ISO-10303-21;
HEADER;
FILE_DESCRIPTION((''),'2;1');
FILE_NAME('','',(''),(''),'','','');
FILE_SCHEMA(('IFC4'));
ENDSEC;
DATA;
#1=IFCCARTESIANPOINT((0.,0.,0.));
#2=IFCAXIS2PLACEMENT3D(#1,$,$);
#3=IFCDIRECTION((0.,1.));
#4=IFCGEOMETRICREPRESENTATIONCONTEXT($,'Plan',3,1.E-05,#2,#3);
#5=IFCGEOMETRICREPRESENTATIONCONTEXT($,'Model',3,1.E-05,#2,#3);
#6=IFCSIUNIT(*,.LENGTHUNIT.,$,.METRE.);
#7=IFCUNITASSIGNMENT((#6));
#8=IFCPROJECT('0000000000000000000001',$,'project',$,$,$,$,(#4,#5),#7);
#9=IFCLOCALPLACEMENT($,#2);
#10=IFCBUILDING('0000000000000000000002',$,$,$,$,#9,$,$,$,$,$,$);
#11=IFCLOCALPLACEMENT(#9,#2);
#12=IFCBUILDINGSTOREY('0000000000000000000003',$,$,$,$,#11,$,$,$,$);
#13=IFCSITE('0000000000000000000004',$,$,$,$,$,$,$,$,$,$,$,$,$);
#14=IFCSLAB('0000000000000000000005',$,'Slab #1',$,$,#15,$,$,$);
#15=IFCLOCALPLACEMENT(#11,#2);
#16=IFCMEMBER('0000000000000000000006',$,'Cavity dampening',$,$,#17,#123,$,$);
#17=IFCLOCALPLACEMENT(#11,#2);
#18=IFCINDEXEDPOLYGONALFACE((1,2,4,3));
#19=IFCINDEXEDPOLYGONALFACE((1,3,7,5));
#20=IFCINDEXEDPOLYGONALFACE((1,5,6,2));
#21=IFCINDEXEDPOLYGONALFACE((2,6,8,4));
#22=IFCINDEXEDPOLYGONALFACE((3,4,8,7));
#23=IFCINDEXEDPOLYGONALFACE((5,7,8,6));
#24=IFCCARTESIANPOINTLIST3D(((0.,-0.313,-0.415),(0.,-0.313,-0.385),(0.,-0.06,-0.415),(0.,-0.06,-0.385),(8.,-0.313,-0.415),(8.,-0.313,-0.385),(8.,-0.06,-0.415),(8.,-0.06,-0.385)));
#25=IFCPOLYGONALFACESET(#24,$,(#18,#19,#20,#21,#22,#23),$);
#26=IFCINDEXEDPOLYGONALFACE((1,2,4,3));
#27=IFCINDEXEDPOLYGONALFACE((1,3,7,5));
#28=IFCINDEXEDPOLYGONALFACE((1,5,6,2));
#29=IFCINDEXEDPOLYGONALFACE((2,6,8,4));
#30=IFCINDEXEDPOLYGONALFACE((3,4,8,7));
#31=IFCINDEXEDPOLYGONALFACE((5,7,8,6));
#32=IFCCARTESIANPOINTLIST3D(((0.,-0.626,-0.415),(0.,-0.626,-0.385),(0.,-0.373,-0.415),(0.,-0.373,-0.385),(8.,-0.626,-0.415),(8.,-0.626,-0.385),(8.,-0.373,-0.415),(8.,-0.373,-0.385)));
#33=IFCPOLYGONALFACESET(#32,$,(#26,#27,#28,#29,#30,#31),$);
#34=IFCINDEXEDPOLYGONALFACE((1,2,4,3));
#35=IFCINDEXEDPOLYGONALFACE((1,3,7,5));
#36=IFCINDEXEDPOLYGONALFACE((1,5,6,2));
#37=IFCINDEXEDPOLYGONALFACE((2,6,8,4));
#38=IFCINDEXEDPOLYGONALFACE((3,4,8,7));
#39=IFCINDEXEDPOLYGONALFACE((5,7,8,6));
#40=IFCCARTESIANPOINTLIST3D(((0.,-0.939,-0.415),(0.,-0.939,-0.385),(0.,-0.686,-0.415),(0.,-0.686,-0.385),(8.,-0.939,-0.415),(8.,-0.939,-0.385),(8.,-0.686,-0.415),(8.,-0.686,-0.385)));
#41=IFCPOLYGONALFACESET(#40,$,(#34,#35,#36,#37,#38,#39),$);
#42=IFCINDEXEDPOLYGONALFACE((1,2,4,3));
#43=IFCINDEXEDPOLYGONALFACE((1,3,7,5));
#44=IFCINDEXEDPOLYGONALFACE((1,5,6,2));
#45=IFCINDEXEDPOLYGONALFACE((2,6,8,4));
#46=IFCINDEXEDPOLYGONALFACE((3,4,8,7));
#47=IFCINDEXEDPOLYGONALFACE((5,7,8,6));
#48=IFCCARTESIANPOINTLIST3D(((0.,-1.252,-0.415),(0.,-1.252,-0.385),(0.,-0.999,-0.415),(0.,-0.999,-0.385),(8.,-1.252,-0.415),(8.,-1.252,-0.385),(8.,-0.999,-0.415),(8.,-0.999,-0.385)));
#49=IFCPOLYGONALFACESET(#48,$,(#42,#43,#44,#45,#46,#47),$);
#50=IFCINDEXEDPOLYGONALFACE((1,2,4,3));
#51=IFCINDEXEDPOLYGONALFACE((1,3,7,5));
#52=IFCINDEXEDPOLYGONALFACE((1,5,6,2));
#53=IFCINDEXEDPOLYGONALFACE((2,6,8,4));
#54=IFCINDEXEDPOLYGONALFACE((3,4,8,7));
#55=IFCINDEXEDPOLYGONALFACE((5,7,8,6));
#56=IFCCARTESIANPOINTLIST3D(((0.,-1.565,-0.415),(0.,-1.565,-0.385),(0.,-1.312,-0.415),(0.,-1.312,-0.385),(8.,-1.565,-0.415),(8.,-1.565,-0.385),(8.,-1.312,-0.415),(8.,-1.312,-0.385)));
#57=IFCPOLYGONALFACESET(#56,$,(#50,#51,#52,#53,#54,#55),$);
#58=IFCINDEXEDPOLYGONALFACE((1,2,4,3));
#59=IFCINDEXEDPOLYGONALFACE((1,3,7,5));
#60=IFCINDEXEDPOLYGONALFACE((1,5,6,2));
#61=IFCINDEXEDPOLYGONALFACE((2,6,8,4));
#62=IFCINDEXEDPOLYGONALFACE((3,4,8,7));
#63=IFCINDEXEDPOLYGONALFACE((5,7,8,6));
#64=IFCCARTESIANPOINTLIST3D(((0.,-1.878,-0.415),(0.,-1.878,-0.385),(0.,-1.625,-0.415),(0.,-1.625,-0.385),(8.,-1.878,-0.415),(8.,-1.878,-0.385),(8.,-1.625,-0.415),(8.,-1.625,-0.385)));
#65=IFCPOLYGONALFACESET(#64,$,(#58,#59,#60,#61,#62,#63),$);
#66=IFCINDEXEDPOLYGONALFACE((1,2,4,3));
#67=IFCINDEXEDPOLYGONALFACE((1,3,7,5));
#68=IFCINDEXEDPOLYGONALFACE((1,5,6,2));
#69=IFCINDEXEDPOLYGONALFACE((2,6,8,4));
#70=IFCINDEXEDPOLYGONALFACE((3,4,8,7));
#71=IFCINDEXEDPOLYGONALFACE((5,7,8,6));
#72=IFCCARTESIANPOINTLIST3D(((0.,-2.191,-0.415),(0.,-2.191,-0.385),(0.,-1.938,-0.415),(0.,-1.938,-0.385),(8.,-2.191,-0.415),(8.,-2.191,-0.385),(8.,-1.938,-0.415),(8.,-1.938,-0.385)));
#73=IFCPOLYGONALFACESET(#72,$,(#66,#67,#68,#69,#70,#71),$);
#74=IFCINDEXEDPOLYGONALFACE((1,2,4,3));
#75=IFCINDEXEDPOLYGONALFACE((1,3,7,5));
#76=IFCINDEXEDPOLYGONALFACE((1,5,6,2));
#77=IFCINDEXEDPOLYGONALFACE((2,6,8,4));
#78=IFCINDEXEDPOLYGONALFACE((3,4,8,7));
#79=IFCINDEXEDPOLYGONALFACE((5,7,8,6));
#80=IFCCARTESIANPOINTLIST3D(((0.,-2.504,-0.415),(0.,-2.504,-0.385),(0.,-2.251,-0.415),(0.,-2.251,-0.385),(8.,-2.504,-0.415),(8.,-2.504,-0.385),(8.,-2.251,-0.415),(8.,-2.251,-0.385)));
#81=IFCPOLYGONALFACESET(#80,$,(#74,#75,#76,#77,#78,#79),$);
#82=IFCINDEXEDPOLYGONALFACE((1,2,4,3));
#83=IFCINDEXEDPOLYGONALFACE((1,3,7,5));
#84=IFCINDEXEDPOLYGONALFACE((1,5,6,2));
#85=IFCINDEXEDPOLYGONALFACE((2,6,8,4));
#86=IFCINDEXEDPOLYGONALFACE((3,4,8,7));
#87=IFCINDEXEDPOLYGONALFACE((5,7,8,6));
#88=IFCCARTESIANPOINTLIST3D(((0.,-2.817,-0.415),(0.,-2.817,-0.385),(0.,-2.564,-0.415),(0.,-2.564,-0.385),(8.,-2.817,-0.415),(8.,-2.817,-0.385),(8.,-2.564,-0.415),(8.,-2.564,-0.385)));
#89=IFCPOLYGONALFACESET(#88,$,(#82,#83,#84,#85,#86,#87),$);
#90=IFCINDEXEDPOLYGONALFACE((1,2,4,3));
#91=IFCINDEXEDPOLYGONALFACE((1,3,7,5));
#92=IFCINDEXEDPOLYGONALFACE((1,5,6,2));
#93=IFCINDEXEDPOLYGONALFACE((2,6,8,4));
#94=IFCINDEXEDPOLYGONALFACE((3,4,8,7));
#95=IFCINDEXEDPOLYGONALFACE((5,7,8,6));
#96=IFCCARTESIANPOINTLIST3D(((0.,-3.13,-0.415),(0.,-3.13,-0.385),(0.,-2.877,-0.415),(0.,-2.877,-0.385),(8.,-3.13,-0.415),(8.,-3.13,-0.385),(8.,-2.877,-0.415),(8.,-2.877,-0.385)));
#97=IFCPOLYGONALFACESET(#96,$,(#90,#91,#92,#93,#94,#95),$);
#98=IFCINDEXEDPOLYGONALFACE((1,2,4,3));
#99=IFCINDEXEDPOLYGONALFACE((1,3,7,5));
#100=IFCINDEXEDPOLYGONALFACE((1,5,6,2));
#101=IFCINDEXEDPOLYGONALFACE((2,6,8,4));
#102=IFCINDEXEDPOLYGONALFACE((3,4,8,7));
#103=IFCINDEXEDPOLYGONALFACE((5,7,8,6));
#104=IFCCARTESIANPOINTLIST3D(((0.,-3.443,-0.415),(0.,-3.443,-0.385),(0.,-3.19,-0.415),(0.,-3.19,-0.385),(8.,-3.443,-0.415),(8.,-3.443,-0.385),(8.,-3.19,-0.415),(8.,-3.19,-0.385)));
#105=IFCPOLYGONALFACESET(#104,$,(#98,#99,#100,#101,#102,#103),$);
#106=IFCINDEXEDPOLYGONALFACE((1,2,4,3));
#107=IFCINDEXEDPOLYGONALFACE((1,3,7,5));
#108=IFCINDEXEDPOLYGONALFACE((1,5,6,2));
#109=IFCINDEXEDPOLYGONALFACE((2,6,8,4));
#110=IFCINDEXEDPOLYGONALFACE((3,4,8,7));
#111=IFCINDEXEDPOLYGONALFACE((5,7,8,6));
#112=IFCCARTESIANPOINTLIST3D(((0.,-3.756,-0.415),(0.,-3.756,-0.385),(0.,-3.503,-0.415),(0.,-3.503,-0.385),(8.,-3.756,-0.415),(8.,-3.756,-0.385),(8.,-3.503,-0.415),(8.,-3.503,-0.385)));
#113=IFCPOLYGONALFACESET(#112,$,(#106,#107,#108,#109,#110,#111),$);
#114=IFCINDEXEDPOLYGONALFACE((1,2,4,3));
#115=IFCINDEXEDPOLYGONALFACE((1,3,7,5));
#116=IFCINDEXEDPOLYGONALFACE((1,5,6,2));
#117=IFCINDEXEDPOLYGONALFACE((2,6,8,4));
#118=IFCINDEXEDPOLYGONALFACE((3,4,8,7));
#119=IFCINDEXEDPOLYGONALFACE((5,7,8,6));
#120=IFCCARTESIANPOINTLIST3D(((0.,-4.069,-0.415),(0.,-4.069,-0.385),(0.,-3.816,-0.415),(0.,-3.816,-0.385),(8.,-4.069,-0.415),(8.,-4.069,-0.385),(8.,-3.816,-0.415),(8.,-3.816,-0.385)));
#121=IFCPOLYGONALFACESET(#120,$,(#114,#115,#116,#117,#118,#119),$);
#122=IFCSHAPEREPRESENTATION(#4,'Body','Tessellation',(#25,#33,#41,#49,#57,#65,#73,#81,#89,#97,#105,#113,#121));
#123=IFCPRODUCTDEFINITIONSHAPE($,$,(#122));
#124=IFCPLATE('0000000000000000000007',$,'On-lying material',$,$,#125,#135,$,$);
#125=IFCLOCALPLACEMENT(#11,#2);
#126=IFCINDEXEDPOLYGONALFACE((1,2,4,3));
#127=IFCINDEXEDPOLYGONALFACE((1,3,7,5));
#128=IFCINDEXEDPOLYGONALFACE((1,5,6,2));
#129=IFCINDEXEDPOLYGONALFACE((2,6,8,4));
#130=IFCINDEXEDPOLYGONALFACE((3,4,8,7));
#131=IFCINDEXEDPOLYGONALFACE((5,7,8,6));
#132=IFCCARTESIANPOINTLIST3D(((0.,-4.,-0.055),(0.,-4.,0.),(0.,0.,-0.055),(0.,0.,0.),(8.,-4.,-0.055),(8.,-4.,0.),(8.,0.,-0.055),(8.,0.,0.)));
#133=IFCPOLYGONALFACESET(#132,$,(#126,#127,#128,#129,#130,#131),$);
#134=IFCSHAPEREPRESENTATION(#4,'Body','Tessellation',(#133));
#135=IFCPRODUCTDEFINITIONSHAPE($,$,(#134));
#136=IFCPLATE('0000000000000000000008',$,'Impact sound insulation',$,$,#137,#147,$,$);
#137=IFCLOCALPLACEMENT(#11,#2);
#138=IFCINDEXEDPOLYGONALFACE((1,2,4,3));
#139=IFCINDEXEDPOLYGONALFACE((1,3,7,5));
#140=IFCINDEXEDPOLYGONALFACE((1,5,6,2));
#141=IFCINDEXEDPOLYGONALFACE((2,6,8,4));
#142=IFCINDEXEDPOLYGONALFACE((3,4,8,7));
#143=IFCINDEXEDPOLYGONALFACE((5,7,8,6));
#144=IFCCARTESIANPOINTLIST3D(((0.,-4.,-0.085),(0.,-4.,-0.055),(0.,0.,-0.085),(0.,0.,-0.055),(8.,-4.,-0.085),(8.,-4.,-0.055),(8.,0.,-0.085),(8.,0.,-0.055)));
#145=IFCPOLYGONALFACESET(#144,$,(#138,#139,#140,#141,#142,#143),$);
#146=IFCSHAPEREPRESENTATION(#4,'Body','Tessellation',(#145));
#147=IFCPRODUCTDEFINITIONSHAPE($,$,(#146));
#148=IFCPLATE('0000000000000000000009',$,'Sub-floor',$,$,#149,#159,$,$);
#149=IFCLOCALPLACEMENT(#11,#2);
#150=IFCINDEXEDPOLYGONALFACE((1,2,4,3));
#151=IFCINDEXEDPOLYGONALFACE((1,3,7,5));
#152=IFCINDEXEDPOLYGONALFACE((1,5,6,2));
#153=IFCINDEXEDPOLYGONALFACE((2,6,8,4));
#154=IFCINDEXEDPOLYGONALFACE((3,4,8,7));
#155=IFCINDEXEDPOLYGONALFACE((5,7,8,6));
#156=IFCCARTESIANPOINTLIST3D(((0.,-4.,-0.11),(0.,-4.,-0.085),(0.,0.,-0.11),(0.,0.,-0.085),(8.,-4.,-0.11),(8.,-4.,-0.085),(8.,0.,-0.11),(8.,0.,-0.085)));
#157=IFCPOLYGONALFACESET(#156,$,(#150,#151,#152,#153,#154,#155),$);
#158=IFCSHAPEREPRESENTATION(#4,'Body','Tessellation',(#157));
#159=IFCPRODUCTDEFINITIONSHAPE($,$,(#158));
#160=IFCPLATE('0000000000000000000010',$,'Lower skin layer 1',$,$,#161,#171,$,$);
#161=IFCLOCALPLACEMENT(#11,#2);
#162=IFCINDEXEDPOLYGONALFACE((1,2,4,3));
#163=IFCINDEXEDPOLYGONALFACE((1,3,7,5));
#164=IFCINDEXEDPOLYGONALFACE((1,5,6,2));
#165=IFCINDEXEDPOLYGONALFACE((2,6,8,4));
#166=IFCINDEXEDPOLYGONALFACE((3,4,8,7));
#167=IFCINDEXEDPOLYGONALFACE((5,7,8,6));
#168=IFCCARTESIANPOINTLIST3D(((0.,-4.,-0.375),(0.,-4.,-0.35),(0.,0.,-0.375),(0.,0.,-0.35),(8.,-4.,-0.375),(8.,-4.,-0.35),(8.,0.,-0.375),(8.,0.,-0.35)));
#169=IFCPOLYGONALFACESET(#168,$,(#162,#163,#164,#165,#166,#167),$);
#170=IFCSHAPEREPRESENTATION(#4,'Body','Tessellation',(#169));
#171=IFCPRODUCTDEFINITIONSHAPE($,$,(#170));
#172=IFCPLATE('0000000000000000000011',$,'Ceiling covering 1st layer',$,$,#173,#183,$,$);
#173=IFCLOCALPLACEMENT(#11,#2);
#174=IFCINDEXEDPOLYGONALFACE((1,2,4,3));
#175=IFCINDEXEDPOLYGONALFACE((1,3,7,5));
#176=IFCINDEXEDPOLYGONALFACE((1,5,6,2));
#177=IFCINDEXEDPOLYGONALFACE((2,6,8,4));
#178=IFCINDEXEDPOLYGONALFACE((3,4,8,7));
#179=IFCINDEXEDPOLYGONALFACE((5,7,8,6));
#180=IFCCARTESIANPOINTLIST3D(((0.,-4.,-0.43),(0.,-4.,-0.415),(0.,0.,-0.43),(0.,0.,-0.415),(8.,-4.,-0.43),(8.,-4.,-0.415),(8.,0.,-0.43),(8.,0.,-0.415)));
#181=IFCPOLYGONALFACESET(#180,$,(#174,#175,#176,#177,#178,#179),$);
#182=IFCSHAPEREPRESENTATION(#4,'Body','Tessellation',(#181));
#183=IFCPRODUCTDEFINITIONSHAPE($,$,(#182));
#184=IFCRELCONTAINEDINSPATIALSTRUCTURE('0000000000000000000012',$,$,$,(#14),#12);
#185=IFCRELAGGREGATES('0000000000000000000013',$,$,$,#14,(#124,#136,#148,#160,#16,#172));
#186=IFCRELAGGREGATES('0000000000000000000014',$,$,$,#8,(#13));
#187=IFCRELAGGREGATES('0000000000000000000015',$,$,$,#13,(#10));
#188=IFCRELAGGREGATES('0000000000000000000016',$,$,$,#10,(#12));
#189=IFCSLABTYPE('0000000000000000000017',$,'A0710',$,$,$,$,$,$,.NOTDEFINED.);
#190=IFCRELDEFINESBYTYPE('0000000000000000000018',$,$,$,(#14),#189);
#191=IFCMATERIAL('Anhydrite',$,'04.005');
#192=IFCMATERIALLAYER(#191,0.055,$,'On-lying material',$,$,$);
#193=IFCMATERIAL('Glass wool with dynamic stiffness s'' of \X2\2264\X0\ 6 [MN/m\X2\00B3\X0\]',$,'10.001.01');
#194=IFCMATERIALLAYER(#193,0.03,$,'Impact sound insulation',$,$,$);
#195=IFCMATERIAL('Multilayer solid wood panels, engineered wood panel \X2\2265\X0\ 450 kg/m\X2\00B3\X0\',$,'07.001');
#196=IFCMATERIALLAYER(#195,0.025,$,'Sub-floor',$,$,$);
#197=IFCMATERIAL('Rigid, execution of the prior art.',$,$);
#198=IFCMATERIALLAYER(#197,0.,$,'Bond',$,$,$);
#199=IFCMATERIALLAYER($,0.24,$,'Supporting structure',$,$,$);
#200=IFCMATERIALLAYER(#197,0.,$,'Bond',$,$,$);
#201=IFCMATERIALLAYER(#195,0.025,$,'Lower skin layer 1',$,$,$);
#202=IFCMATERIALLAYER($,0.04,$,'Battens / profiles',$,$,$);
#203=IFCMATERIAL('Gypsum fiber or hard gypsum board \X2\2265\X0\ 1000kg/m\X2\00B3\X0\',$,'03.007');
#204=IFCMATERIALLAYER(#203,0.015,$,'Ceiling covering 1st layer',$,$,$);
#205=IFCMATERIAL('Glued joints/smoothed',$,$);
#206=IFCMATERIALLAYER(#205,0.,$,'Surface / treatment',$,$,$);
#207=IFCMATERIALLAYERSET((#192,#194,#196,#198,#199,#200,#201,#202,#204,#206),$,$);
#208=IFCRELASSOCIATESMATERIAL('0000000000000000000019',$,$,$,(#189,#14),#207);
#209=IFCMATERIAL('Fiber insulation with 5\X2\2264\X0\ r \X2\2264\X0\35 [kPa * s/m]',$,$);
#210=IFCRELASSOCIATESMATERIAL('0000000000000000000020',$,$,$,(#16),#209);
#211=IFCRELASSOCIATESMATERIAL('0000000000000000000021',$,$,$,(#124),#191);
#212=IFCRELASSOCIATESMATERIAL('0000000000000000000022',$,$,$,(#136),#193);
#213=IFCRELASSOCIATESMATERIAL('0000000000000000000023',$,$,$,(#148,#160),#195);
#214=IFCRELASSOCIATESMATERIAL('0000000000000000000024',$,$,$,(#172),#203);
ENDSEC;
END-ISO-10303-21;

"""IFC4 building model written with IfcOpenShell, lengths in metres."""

from ifc_helpers import new_model, si_unit, direction, frame, frame_2d, origin, origin_with_axes, place, context, project, spatial, rectangle, extrude, material, layer, layer_set, type_object, element, aggregate, save


model = new_model("IFC4")

# Units and contexts
plan_context = context("Plan", 3, precision=1e-05, world=origin(), true_north=direction((0.0, 1.0)))
model_context = context("Model", 3, precision=1e-05, world=origin(), true_north=direction((0.0, 1.0)))
ifc_project = project(units=[si_unit("LENGTHUNIT", "METRE")], contexts=[plan_context, model_context])

# Site, building, storey
site = spatial("IfcSite", under=ifc_project)
building_placement = place(None, origin())
building = spatial("IfcBuilding", under=site, at=building_placement)
storey_placement = place(building_placement, origin())
storey = spatial("IfcBuildingStorey", under=building, at=storey_placement)

# Slab, member, plates
ifc_material_1 = material(Name="Anhydrite", Category="04.005")
ifc_layer_1 = layer(ifc_material_1, 0.055, Name="On-lying material")
ifc_material_2 = material(Name="Glass wool with dynamic stiffness s' of ≤ 6 [MN/m³]", Category="10.001.01")
ifc_layer_2 = layer(ifc_material_2, 0.03, Name="Impact sound insulation")
ifc_material_3 = material(Name="Multilayer solid wood panels, engineered wood panel ≥ 450 kg/m³", Category="07.001")
ifc_layer_3 = layer(ifc_material_3, 0.025, Name="Sub-floor")
ifc_material_4 = material(Name="Rigid, execution of the prior art.")
ifc_layer_4 = layer(ifc_material_4, 0.0, Name="Bond")
ifc_layer_5 = layer(None, 0.24, Name="Supporting structure")
ifc_layer_6 = layer(ifc_material_4, 0.0, Name="Bond")
ifc_layer_7 = layer(ifc_material_3, 0.025, Name="Lower skin layer 1")
ifc_layer_8 = layer(None, 0.04, Name="Battens / profiles")
ifc_material_5 = material(Name="Gypsum fiber or hard gypsum board ≥ 1000kg/m³", Category="03.007")
ifc_layer_9 = layer(ifc_material_5, 0.015, Name="Ceiling covering 1st layer")
ifc_material_6 = material(Name="Glued joints/smoothed")
ifc_layer_10 = layer(ifc_material_6, 0.0, Name="Surface / treatment")
ifc_layer_set = layer_set([ifc_layer_1, ifc_layer_2, ifc_layer_3, ifc_layer_4, ifc_layer_5, ifc_layer_6, ifc_layer_7, ifc_layer_8, ifc_layer_9, ifc_layer_10])
slab_type = type_object("IfcSlabType", Name="A0710", PredefinedType="NOTDEFINED", material=ifc_layer_set)
slab_placement = place(None, frame((0.0, 0.0, 0.0), z_axis=(0.0, 0.0, -1.0), x_axis=(1.0, 0.0, 0.0)))
slab = element("IfcSlab", 1, at=slab_placement, inside=storey, type_object=slab_type, material=ifc_layer_set, Name="Slab #1")
ifc_material_7 = material(Name="Fiber insulation with 5≤ r ≤35 [kPa * s/m]")
member_1_placement = place(slab_placement, origin())
member_1 = element("IfcMember", 2, at=member_1_placement, material=ifc_material_7, Name="Cavity dampening", context=plan_context, shape_type="SweptSolid", body=[
    extrude(rectangle(XDim=0.253, YDim=0.03, at=frame_2d((0.1265, 0.015), x_axis=(1.0, 0.0))), frame((0.0, 0.06, 0.385), z_axis=(1.0, 0.0, 0.0), x_axis=(0.0, 1.0, 0.0)), (0.0, 0.0, 1.0), 8.0),
    extrude(rectangle(XDim=0.253, YDim=0.03, at=frame_2d((0.1265, 0.015), x_axis=(1.0, 0.0))), frame((0.0, 0.373, 0.385), z_axis=(1.0, 0.0, 0.0), x_axis=(0.0, 1.0, 0.0)), (0.0, 0.0, 1.0), 8.0),
    extrude(rectangle(XDim=0.253, YDim=0.03, at=frame_2d((0.1265, 0.015), x_axis=(1.0, 0.0))), frame((0.0, 0.686, 0.385), z_axis=(1.0, 0.0, 0.0), x_axis=(0.0, 1.0, 0.0)), (0.0, 0.0, 1.0), 8.0),
    extrude(rectangle(XDim=0.253, YDim=0.03, at=frame_2d((0.1265, 0.015), x_axis=(1.0, 0.0))), frame((0.0, 0.999, 0.385), z_axis=(1.0, 0.0, 0.0), x_axis=(0.0, 1.0, 0.0)), (0.0, 0.0, 1.0), 8.0),
    extrude(rectangle(XDim=0.253, YDim=0.03, at=frame_2d((0.1265, 0.015), x_axis=(1.0, 0.0))), frame((0.0, 1.312, 0.385), z_axis=(1.0, 0.0, 0.0), x_axis=(0.0, 1.0, 0.0)), (0.0, 0.0, 1.0), 8.0),
    extrude(rectangle(XDim=0.253, YDim=0.03, at=frame_2d((0.1265, 0.015), x_axis=(1.0, 0.0))), frame((0.0, 1.625, 0.385), z_axis=(1.0, 0.0, 0.0), x_axis=(0.0, 1.0, 0.0)), (0.0, 0.0, 1.0), 8.0),
    extrude(rectangle(XDim=0.253, YDim=0.03, at=frame_2d((0.1265, 0.015), x_axis=(1.0, 0.0))), frame((0.0, 1.938, 0.385), z_axis=(1.0, 0.0, 0.0), x_axis=(0.0, 1.0, 0.0)), (0.0, 0.0, 1.0), 8.0),
    extrude(rectangle(XDim=0.253, YDim=0.03, at=frame_2d((0.1265, 0.015), x_axis=(1.0, 0.0))), frame((0.0, 2.251, 0.385), z_axis=(1.0, 0.0, 0.0), x_axis=(0.0, 1.0, 0.0)), (0.0, 0.0, 1.0), 8.0),
    extrude(rectangle(XDim=0.253, YDim=0.03, at=frame_2d((0.1265, 0.015), x_axis=(1.0, 0.0))), frame((0.0, 2.564, 0.385), z_axis=(1.0, 0.0, 0.0), x_axis=(0.0, 1.0, 0.0)), (0.0, 0.0, 1.0), 8.0),
    extrude(rectangle(XDim=0.253, YDim=0.03, at=frame_2d((0.1265, 0.015), x_axis=(1.0, 0.0))), frame((0.0, 2.877, 0.385), z_axis=(1.0, 0.0, 0.0), x_axis=(0.0, 1.0, 0.0)), (0.0, 0.0, 1.0), 8.0),
    extrude(rectangle(XDim=0.253, YDim=0.03, at=frame_2d((0.1265, 0.015), x_axis=(1.0, 0.0))), frame((0.0, 3.19, 0.385), z_axis=(1.0, 0.0, 0.0), x_axis=(0.0, 1.0, 0.0)), (0.0, 0.0, 1.0), 8.0),
    extrude(rectangle(XDim=0.253, YDim=0.03, at=frame_2d((0.1265, 0.015), x_axis=(1.0, 0.0))), frame((0.0, 3.503, 0.385), z_axis=(1.0, 0.0, 0.0), x_axis=(0.0, 1.0, 0.0)), (0.0, 0.0, 1.0), 8.0),
    extrude(rectangle(XDim=0.253, YDim=0.03, at=frame_2d((0.1265, 0.015), x_axis=(1.0, 0.0))), frame((0.0, 3.816, 0.385), z_axis=(1.0, 0.0, 0.0), x_axis=(0.0, 1.0, 0.0)), (0.0, 0.0, 1.0), 8.0),
])
plate_1_placement = place(slab_placement, origin())
plate_1 = element("IfcPlate", 3, at=plate_1_placement, material=ifc_material_1, Name="On-lying material", context=plan_context, shape_type="SweptSolid", body=[
    extrude(rectangle(XDim=8.0, YDim=4.0, at=frame_2d((4.0, 2.0), x_axis=(1.0, 0.0))), origin_with_axes(), (0.0, 0.0, 1.0), 0.055),
])
plate_2_placement = place(slab_placement, origin())
plate_2 = element("IfcPlate", 4, at=plate_2_placement, material=ifc_material_2, Name="Impact sound insulation", context=plan_context, shape_type="SweptSolid", body=[
    extrude(rectangle(XDim=8.0, YDim=4.0, at=frame_2d((4.0, 2.0), x_axis=(1.0, 0.0))), frame((0.0, 0.0, 0.055), z_axis=(0.0, 0.0, 1.0), x_axis=(1.0, 0.0, 0.0)), (0.0, 0.0, 1.0), 0.03),
])
plate_3_placement = place(slab_placement, origin())
plate_3 = element("IfcPlate", 5, at=plate_3_placement, material=ifc_material_3, Name="Sub-floor", context=plan_context, shape_type="SweptSolid", body=[
    extrude(rectangle(XDim=8.0, YDim=4.0, at=frame_2d((4.0, 2.0), x_axis=(1.0, 0.0))), frame((0.0, 0.0, 0.085), z_axis=(0.0, 0.0, 1.0), x_axis=(1.0, 0.0, 0.0)), (0.0, 0.0, 1.0), 0.025),
])
plate_4_placement = place(slab_placement, origin())
plate_4 = element("IfcPlate", 6, at=plate_4_placement, material=ifc_material_3, Name="Lower skin layer 1", context=plan_context, shape_type="SweptSolid", body=[
    extrude(rectangle(XDim=8.0, YDim=4.0, at=frame_2d((4.0, 2.0), x_axis=(1.0, 0.0))), frame((0.0, 0.0, 0.35), z_axis=(0.0, 0.0, 1.0), x_axis=(1.0, 0.0, 0.0)), (0.0, 0.0, 1.0), 0.025),
])
plate_5_placement = place(slab_placement, origin())
plate_5 = element("IfcPlate", 7, at=plate_5_placement, material=ifc_material_5, Name="Ceiling covering 1st layer", context=plan_context, shape_type="SweptSolid", body=[
    extrude(rectangle(XDim=8.0, YDim=4.0, at=frame_2d((4.0, 2.0), x_axis=(1.0, 0.0))), frame((0.0, 0.0, 0.415), z_axis=(0.0, 0.0, 1.0), x_axis=(1.0, 0.0, 0.0)), (0.0, 0.0, 1.0), 0.015),
])
aggregate(slab, [plate_1, plate_2, plate_3, plate_4, member_1, plate_5])

save(model, "model.ifc")
